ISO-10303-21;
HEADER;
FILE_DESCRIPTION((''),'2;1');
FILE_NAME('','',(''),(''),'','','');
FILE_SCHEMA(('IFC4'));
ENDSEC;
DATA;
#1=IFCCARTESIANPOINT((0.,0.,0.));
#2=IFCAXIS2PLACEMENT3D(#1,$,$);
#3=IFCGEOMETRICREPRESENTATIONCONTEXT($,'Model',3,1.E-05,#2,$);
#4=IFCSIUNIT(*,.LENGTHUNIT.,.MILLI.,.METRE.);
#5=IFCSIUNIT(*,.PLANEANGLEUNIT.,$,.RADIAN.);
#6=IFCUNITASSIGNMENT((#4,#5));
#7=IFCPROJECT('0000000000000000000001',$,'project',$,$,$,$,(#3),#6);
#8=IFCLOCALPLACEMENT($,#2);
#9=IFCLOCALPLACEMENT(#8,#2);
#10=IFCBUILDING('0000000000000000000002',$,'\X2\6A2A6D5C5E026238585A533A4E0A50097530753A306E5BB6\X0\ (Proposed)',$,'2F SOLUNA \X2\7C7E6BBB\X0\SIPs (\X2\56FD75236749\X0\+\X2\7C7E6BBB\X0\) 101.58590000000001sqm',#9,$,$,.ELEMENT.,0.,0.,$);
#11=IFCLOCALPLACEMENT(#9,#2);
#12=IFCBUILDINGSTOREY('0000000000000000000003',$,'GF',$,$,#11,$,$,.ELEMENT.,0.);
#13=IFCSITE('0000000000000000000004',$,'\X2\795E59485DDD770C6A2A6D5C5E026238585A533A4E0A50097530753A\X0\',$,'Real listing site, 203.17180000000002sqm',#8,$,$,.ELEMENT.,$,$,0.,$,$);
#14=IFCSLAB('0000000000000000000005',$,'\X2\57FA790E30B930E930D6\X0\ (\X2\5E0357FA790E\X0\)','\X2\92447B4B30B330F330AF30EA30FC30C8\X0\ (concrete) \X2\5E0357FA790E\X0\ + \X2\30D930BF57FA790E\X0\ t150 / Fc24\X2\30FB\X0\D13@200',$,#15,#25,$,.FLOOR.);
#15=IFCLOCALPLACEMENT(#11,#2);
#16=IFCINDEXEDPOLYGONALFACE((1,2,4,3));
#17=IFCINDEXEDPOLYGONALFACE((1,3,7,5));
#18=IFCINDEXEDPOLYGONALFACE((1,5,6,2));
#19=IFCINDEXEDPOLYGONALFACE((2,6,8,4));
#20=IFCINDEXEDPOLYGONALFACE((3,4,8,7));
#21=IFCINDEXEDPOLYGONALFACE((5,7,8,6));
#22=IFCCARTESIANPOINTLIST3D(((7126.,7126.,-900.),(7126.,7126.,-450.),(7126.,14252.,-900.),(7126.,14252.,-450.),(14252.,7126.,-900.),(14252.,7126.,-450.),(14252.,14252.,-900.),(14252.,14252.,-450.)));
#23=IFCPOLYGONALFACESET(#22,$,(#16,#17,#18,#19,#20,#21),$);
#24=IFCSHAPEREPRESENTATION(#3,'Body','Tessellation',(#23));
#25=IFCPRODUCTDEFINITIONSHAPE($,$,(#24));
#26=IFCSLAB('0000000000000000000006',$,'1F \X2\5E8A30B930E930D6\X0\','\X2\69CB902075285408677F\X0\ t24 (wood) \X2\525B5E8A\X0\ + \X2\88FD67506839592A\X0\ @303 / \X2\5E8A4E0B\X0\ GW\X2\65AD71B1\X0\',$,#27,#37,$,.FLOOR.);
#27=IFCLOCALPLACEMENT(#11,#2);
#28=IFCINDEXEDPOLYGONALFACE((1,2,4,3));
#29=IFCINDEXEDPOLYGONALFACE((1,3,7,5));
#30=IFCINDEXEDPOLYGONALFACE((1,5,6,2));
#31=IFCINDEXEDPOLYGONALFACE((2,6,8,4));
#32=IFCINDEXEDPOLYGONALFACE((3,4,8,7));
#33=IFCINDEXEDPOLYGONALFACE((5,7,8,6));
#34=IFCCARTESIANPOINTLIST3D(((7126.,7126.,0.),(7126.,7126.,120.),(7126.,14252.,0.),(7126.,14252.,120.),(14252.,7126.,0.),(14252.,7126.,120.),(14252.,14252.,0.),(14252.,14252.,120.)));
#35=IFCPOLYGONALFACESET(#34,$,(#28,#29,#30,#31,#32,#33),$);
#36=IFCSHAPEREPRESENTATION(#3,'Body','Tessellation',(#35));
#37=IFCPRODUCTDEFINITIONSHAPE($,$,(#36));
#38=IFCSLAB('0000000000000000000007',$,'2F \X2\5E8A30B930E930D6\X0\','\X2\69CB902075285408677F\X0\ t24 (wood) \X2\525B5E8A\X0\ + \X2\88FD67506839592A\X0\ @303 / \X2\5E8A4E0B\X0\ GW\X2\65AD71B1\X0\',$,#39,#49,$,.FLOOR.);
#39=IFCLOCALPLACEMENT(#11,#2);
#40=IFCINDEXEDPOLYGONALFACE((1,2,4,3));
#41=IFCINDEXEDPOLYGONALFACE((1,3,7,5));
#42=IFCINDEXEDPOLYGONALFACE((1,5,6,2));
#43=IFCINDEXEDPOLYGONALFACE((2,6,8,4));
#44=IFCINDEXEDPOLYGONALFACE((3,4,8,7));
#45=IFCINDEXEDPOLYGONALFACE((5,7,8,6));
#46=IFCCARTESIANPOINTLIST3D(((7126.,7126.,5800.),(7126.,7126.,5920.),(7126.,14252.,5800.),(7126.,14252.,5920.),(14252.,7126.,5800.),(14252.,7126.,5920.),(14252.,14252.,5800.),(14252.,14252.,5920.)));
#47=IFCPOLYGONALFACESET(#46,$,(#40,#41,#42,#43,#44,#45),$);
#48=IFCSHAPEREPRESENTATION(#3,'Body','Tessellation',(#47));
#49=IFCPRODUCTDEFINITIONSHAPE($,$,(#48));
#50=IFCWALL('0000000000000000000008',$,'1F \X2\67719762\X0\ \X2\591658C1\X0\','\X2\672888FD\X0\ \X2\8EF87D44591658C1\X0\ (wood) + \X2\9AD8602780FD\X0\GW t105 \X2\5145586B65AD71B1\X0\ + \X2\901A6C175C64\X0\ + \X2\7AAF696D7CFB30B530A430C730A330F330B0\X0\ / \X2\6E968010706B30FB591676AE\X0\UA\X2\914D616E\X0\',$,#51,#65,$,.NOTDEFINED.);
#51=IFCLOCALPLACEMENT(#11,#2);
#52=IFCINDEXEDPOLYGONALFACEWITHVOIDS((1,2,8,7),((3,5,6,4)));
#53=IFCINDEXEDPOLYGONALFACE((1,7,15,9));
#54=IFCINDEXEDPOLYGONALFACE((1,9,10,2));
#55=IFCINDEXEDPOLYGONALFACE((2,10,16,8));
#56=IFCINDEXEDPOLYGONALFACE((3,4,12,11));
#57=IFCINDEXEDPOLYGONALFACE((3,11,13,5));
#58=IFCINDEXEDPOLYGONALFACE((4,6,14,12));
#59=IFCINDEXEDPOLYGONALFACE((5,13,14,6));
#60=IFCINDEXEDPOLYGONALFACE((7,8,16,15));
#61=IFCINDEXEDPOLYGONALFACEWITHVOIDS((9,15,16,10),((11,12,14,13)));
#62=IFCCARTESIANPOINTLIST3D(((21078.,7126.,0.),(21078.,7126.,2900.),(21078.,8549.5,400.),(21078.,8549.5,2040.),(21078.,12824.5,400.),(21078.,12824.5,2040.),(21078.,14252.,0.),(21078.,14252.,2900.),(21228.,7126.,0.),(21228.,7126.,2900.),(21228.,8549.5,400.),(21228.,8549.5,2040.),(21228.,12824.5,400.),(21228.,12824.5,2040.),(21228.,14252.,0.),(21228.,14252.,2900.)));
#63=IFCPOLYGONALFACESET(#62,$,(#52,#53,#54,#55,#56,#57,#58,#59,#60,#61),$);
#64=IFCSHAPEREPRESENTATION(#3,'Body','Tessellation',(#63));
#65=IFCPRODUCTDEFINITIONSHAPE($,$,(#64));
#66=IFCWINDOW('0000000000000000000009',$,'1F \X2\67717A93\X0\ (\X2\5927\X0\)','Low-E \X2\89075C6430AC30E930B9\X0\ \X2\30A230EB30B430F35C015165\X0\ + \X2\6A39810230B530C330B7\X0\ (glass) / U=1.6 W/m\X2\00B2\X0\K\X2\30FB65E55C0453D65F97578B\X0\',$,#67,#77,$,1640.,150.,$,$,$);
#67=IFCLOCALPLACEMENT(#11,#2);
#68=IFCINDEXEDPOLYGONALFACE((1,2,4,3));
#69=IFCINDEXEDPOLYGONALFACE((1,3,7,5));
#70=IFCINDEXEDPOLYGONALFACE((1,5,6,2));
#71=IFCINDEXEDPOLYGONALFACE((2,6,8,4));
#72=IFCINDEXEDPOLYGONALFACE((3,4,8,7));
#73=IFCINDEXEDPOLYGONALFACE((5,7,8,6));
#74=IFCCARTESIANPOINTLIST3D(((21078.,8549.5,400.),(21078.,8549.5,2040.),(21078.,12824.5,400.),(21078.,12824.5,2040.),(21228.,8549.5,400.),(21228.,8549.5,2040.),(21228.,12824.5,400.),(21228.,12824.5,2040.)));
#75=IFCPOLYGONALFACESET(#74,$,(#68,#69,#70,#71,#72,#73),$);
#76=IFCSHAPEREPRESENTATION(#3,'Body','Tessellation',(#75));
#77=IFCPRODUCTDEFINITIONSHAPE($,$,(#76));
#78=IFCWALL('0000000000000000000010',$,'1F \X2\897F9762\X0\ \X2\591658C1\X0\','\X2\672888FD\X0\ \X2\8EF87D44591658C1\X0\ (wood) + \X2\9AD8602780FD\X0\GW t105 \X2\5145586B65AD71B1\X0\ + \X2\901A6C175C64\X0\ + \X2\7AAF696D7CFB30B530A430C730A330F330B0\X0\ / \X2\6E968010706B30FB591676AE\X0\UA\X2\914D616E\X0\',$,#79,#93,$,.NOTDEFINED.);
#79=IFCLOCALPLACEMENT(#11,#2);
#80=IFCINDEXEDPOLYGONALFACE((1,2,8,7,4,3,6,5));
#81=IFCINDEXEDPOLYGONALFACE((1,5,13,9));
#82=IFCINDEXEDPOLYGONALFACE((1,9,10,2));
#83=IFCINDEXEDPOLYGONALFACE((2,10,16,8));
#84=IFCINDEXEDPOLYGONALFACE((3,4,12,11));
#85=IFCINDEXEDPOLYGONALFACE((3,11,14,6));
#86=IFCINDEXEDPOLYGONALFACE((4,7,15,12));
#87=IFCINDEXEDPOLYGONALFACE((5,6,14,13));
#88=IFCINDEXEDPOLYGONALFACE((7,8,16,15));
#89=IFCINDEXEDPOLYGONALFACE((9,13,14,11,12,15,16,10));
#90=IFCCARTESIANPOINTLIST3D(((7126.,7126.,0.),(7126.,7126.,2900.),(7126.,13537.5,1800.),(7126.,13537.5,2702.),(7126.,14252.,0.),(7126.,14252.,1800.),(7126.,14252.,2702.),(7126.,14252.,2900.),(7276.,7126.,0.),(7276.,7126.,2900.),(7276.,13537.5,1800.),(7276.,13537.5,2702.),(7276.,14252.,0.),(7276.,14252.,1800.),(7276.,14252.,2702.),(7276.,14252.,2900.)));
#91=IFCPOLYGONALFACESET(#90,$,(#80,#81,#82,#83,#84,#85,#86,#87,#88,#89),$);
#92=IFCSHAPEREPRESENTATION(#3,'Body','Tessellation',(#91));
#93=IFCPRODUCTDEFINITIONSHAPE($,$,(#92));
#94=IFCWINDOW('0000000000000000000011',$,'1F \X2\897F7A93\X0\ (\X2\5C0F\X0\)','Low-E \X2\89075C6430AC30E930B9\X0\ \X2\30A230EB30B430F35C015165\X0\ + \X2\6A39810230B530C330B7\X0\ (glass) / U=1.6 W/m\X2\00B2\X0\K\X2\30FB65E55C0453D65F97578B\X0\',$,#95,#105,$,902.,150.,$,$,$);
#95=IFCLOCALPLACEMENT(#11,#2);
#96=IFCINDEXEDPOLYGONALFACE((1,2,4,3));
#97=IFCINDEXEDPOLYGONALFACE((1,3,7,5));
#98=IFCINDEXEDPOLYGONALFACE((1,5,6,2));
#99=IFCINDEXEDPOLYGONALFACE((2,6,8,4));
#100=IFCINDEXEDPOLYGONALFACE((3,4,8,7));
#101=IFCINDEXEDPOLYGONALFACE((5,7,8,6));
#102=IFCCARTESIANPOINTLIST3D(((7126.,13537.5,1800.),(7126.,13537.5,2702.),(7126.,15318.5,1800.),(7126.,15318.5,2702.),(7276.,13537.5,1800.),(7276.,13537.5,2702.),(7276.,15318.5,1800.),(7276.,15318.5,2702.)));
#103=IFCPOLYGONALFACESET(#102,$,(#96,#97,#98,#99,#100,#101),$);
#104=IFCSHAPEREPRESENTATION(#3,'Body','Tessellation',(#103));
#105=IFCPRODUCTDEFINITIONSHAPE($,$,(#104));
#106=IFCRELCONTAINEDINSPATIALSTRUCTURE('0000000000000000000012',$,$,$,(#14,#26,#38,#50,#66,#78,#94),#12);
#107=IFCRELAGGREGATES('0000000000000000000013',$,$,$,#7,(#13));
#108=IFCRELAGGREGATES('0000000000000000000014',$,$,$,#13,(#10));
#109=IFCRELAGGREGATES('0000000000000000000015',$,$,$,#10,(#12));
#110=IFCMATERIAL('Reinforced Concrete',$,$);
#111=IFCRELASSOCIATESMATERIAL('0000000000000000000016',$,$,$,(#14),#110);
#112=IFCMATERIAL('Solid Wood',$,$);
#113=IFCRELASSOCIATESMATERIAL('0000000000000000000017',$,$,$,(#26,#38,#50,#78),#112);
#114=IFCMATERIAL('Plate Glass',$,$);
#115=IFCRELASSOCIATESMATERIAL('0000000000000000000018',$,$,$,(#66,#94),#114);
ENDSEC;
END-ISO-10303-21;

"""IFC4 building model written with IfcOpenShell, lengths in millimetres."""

from ifc_helpers import new_model, si_unit, frame, frame_2d, origin, place, context, project, spatial, rectangle, extrude, material, element, fill, save


model = new_model("IFC4")

# Units and contexts
model_context = context("Model", 3, precision=1e-05, world=origin())
ifc_project = project(units=[si_unit("LENGTHUNIT", "METRE", prefix="MILLI"), si_unit("PLANEANGLEUNIT", "RADIAN")], contexts=[model_context])

# Site, building, storey
site_placement = place(None, origin())
site = spatial("IfcSite", under=ifc_project, at=site_placement, Name="神奈川県横浜市戸塚区上倉田町", ObjectType="Real listing site, 203.17180000000002sqm", CompositionType="ELEMENT", RefElevation=0.0)
building_placement = place(site_placement, origin())
building = spatial("IfcBuilding", under=site, at=building_placement, Name="横浜市戸塚区上倉田町の家 (Proposed)", ObjectType="2F SOLUNA 籾殻SIPs (国産杉+籾殻) 101.58590000000001sqm", CompositionType="ELEMENT", ElevationOfRefHeight=0.0, ElevationOfTerrain=0.0)
storey_placement = place(building_placement, origin())
storey = spatial("IfcBuildingStorey", under=building, at=storey_placement, Name="GF", CompositionType="ELEMENT", Elevation=0.0)

# Slabs
ifc_material_1 = material(Name="Reinforced Concrete")
slab_1_placement = place(storey_placement, frame((3563.0, 3563.0, -450.0)))
element("IfcSlab", 1, at=slab_1_placement, inside=storey, material=ifc_material_1, Name="基礎スラブ (布基礎)", Description="鉄筋コンクリート (concrete) 布基礎 + ベタ基礎 t150 / Fc24・D13@200", PredefinedType="FLOOR", context=model_context, shape_type="SweptSolid", body=[
    extrude(rectangle(XDim=7126.0, YDim=7126.0, at=frame_2d((3563.0, 3563.0))), frame((3563.0, 3563.0, -450.0)), (0.0, 0.0, 1.0), 450.0),
])
ifc_material_2 = material(Name="Solid Wood")
slab_2_placement = place(storey_placement, frame((3563.0, 3563.0, 0.0)))
element("IfcSlab", 2, at=slab_2_placement, inside=storey, material=ifc_material_2, Name="1F 床スラブ", Description="構造用合板 t24 (wood) 剛床 + 製材根太 @303 / 床下 GW断熱", PredefinedType="FLOOR", context=model_context, shape_type="SweptSolid", body=[
    extrude(rectangle(XDim=7126.0, YDim=7126.0, at=frame_2d((3563.0, 3563.0))), frame((3563.0, 3563.0, 0.0)), (0.0, 0.0, 1.0), 120.0),
])
slab_3_placement = place(storey_placement, frame((3563.0, 3563.0, 2900.0)))
element("IfcSlab", 3, at=slab_3_placement, inside=storey, material=ifc_material_2, Name="2F 床スラブ", Description="構造用合板 t24 (wood) 剛床 + 製材根太 @303 / 床下 GW断熱", PredefinedType="FLOOR", context=model_context, shape_type="SweptSolid", body=[
    extrude(rectangle(XDim=7126.0, YDim=7126.0, at=frame_2d((3563.0, 3563.0))), frame((3563.0, 3563.0, 2900.0)), (0.0, 0.0, 1.0), 120.0),
])

# Shared definitions
ifc_material_3 = material(Name="Plate Glass")

# Walls, openings, windows
wall_1_placement = place(storey_placement, frame((10539.0, 3563.0, 0.0)))
wall_1 = element("IfcWall", 4, at=wall_1_placement, inside=storey, material=ifc_material_2, Name="1F 東面 外壁", Description="木製 軸組外壁 (wood) + 高性能GW t105 充填断熱 + 通気層 + 窯業系サイディング / 準耐火・外皮UA配慮", PredefinedType="NOTDEFINED", context=model_context, shape_type="SweptSolid", body=[
    extrude(rectangle(XDim=150.0, YDim=7126.0, at=frame_2d((75.0, 3563.0))), frame((10539.0, 3563.0, 0.0)), (0.0, 0.0, 1.0), 2900.0),
])
opening_1_placement = place(storey_placement, frame((10539.0, 4275.0, 200.0)))
opening_1 = element("IfcOpeningElement", 5, at=opening_1_placement, cuts=wall_1, PredefinedType="NOTDEFINED", context=model_context, shape_type="SweptSolid", body=[
    extrude(rectangle(XDim=150.0, YDim=4275.0, at=frame_2d((75.0, 2137.0))), frame((10539.0, 4275.0, 200.0)), (0.0, 0.0, 1.0), 1640.0),
])
window_1_placement = place(storey_placement, frame((10539.0, 4275.0, 200.0)))
window_1 = element("IfcWindow", 6, at=window_1_placement, inside=storey, material=ifc_material_3, Name="1F 東窓 (大)", Description="Low-E 複層ガラス アルゴン封入 + 樹脂サッシ (glass) / U=1.6 W/m²K・日射取得型", OverallHeight=1640.0, OverallWidth=150.0, context=model_context, shape_type="SweptSolid", body=[
    extrude(rectangle(XDim=150.0, YDim=4275.0, at=frame_2d((75.0, 2137.0))), frame((10539.0, 4275.0, 200.0)), (0.0, 0.0, 1.0), 1640.0),
])
fill(opening_1, window_1)
wall_2_placement = place(storey_placement, frame((3563.0, 3563.0, 0.0)))
wall_2 = element("IfcWall", 7, at=wall_2_placement, inside=storey, material=ifc_material_2, Name="1F 西面 外壁", Description="木製 軸組外壁 (wood) + 高性能GW t105 充填断熱 + 通気層 + 窯業系サイディング / 準耐火・外皮UA配慮", PredefinedType="NOTDEFINED", context=model_context, shape_type="SweptSolid", body=[
    extrude(rectangle(XDim=150.0, YDim=7126.0, at=frame_2d((75.0, 3563.0))), frame((3563.0, 3563.0, 0.0)), (0.0, 0.0, 1.0), 2900.0),
])
opening_2_placement = place(storey_placement, frame((3563.0, 6769.0, 900.0)))
opening_2 = element("IfcOpeningElement", 8, at=opening_2_placement, cuts=wall_2, PredefinedType="NOTDEFINED", context=model_context, shape_type="SweptSolid", body=[
    extrude(rectangle(XDim=150.0, YDim=1781.0, at=frame_2d((75.0, 890.0))), frame((3563.0, 6769.0, 900.0)), (0.0, 0.0, 1.0), 902.0),
])
window_2_placement = place(storey_placement, frame((3563.0, 6769.0, 900.0)))
window_2 = element("IfcWindow", 9, at=window_2_placement, inside=storey, material=ifc_material_3, Name="1F 西窓 (小)", Description="Low-E 複層ガラス アルゴン封入 + 樹脂サッシ (glass) / U=1.6 W/m²K・日射取得型", OverallHeight=902.0, OverallWidth=150.0, context=model_context, shape_type="SweptSolid", body=[
    extrude(rectangle(XDim=150.0, YDim=1781.0, at=frame_2d((75.0, 890.0))), frame((3563.0, 6769.0, 900.0)), (0.0, 0.0, 1.0), 902.0),
])
fill(opening_2, window_2)

save(model, "model.ifc")
